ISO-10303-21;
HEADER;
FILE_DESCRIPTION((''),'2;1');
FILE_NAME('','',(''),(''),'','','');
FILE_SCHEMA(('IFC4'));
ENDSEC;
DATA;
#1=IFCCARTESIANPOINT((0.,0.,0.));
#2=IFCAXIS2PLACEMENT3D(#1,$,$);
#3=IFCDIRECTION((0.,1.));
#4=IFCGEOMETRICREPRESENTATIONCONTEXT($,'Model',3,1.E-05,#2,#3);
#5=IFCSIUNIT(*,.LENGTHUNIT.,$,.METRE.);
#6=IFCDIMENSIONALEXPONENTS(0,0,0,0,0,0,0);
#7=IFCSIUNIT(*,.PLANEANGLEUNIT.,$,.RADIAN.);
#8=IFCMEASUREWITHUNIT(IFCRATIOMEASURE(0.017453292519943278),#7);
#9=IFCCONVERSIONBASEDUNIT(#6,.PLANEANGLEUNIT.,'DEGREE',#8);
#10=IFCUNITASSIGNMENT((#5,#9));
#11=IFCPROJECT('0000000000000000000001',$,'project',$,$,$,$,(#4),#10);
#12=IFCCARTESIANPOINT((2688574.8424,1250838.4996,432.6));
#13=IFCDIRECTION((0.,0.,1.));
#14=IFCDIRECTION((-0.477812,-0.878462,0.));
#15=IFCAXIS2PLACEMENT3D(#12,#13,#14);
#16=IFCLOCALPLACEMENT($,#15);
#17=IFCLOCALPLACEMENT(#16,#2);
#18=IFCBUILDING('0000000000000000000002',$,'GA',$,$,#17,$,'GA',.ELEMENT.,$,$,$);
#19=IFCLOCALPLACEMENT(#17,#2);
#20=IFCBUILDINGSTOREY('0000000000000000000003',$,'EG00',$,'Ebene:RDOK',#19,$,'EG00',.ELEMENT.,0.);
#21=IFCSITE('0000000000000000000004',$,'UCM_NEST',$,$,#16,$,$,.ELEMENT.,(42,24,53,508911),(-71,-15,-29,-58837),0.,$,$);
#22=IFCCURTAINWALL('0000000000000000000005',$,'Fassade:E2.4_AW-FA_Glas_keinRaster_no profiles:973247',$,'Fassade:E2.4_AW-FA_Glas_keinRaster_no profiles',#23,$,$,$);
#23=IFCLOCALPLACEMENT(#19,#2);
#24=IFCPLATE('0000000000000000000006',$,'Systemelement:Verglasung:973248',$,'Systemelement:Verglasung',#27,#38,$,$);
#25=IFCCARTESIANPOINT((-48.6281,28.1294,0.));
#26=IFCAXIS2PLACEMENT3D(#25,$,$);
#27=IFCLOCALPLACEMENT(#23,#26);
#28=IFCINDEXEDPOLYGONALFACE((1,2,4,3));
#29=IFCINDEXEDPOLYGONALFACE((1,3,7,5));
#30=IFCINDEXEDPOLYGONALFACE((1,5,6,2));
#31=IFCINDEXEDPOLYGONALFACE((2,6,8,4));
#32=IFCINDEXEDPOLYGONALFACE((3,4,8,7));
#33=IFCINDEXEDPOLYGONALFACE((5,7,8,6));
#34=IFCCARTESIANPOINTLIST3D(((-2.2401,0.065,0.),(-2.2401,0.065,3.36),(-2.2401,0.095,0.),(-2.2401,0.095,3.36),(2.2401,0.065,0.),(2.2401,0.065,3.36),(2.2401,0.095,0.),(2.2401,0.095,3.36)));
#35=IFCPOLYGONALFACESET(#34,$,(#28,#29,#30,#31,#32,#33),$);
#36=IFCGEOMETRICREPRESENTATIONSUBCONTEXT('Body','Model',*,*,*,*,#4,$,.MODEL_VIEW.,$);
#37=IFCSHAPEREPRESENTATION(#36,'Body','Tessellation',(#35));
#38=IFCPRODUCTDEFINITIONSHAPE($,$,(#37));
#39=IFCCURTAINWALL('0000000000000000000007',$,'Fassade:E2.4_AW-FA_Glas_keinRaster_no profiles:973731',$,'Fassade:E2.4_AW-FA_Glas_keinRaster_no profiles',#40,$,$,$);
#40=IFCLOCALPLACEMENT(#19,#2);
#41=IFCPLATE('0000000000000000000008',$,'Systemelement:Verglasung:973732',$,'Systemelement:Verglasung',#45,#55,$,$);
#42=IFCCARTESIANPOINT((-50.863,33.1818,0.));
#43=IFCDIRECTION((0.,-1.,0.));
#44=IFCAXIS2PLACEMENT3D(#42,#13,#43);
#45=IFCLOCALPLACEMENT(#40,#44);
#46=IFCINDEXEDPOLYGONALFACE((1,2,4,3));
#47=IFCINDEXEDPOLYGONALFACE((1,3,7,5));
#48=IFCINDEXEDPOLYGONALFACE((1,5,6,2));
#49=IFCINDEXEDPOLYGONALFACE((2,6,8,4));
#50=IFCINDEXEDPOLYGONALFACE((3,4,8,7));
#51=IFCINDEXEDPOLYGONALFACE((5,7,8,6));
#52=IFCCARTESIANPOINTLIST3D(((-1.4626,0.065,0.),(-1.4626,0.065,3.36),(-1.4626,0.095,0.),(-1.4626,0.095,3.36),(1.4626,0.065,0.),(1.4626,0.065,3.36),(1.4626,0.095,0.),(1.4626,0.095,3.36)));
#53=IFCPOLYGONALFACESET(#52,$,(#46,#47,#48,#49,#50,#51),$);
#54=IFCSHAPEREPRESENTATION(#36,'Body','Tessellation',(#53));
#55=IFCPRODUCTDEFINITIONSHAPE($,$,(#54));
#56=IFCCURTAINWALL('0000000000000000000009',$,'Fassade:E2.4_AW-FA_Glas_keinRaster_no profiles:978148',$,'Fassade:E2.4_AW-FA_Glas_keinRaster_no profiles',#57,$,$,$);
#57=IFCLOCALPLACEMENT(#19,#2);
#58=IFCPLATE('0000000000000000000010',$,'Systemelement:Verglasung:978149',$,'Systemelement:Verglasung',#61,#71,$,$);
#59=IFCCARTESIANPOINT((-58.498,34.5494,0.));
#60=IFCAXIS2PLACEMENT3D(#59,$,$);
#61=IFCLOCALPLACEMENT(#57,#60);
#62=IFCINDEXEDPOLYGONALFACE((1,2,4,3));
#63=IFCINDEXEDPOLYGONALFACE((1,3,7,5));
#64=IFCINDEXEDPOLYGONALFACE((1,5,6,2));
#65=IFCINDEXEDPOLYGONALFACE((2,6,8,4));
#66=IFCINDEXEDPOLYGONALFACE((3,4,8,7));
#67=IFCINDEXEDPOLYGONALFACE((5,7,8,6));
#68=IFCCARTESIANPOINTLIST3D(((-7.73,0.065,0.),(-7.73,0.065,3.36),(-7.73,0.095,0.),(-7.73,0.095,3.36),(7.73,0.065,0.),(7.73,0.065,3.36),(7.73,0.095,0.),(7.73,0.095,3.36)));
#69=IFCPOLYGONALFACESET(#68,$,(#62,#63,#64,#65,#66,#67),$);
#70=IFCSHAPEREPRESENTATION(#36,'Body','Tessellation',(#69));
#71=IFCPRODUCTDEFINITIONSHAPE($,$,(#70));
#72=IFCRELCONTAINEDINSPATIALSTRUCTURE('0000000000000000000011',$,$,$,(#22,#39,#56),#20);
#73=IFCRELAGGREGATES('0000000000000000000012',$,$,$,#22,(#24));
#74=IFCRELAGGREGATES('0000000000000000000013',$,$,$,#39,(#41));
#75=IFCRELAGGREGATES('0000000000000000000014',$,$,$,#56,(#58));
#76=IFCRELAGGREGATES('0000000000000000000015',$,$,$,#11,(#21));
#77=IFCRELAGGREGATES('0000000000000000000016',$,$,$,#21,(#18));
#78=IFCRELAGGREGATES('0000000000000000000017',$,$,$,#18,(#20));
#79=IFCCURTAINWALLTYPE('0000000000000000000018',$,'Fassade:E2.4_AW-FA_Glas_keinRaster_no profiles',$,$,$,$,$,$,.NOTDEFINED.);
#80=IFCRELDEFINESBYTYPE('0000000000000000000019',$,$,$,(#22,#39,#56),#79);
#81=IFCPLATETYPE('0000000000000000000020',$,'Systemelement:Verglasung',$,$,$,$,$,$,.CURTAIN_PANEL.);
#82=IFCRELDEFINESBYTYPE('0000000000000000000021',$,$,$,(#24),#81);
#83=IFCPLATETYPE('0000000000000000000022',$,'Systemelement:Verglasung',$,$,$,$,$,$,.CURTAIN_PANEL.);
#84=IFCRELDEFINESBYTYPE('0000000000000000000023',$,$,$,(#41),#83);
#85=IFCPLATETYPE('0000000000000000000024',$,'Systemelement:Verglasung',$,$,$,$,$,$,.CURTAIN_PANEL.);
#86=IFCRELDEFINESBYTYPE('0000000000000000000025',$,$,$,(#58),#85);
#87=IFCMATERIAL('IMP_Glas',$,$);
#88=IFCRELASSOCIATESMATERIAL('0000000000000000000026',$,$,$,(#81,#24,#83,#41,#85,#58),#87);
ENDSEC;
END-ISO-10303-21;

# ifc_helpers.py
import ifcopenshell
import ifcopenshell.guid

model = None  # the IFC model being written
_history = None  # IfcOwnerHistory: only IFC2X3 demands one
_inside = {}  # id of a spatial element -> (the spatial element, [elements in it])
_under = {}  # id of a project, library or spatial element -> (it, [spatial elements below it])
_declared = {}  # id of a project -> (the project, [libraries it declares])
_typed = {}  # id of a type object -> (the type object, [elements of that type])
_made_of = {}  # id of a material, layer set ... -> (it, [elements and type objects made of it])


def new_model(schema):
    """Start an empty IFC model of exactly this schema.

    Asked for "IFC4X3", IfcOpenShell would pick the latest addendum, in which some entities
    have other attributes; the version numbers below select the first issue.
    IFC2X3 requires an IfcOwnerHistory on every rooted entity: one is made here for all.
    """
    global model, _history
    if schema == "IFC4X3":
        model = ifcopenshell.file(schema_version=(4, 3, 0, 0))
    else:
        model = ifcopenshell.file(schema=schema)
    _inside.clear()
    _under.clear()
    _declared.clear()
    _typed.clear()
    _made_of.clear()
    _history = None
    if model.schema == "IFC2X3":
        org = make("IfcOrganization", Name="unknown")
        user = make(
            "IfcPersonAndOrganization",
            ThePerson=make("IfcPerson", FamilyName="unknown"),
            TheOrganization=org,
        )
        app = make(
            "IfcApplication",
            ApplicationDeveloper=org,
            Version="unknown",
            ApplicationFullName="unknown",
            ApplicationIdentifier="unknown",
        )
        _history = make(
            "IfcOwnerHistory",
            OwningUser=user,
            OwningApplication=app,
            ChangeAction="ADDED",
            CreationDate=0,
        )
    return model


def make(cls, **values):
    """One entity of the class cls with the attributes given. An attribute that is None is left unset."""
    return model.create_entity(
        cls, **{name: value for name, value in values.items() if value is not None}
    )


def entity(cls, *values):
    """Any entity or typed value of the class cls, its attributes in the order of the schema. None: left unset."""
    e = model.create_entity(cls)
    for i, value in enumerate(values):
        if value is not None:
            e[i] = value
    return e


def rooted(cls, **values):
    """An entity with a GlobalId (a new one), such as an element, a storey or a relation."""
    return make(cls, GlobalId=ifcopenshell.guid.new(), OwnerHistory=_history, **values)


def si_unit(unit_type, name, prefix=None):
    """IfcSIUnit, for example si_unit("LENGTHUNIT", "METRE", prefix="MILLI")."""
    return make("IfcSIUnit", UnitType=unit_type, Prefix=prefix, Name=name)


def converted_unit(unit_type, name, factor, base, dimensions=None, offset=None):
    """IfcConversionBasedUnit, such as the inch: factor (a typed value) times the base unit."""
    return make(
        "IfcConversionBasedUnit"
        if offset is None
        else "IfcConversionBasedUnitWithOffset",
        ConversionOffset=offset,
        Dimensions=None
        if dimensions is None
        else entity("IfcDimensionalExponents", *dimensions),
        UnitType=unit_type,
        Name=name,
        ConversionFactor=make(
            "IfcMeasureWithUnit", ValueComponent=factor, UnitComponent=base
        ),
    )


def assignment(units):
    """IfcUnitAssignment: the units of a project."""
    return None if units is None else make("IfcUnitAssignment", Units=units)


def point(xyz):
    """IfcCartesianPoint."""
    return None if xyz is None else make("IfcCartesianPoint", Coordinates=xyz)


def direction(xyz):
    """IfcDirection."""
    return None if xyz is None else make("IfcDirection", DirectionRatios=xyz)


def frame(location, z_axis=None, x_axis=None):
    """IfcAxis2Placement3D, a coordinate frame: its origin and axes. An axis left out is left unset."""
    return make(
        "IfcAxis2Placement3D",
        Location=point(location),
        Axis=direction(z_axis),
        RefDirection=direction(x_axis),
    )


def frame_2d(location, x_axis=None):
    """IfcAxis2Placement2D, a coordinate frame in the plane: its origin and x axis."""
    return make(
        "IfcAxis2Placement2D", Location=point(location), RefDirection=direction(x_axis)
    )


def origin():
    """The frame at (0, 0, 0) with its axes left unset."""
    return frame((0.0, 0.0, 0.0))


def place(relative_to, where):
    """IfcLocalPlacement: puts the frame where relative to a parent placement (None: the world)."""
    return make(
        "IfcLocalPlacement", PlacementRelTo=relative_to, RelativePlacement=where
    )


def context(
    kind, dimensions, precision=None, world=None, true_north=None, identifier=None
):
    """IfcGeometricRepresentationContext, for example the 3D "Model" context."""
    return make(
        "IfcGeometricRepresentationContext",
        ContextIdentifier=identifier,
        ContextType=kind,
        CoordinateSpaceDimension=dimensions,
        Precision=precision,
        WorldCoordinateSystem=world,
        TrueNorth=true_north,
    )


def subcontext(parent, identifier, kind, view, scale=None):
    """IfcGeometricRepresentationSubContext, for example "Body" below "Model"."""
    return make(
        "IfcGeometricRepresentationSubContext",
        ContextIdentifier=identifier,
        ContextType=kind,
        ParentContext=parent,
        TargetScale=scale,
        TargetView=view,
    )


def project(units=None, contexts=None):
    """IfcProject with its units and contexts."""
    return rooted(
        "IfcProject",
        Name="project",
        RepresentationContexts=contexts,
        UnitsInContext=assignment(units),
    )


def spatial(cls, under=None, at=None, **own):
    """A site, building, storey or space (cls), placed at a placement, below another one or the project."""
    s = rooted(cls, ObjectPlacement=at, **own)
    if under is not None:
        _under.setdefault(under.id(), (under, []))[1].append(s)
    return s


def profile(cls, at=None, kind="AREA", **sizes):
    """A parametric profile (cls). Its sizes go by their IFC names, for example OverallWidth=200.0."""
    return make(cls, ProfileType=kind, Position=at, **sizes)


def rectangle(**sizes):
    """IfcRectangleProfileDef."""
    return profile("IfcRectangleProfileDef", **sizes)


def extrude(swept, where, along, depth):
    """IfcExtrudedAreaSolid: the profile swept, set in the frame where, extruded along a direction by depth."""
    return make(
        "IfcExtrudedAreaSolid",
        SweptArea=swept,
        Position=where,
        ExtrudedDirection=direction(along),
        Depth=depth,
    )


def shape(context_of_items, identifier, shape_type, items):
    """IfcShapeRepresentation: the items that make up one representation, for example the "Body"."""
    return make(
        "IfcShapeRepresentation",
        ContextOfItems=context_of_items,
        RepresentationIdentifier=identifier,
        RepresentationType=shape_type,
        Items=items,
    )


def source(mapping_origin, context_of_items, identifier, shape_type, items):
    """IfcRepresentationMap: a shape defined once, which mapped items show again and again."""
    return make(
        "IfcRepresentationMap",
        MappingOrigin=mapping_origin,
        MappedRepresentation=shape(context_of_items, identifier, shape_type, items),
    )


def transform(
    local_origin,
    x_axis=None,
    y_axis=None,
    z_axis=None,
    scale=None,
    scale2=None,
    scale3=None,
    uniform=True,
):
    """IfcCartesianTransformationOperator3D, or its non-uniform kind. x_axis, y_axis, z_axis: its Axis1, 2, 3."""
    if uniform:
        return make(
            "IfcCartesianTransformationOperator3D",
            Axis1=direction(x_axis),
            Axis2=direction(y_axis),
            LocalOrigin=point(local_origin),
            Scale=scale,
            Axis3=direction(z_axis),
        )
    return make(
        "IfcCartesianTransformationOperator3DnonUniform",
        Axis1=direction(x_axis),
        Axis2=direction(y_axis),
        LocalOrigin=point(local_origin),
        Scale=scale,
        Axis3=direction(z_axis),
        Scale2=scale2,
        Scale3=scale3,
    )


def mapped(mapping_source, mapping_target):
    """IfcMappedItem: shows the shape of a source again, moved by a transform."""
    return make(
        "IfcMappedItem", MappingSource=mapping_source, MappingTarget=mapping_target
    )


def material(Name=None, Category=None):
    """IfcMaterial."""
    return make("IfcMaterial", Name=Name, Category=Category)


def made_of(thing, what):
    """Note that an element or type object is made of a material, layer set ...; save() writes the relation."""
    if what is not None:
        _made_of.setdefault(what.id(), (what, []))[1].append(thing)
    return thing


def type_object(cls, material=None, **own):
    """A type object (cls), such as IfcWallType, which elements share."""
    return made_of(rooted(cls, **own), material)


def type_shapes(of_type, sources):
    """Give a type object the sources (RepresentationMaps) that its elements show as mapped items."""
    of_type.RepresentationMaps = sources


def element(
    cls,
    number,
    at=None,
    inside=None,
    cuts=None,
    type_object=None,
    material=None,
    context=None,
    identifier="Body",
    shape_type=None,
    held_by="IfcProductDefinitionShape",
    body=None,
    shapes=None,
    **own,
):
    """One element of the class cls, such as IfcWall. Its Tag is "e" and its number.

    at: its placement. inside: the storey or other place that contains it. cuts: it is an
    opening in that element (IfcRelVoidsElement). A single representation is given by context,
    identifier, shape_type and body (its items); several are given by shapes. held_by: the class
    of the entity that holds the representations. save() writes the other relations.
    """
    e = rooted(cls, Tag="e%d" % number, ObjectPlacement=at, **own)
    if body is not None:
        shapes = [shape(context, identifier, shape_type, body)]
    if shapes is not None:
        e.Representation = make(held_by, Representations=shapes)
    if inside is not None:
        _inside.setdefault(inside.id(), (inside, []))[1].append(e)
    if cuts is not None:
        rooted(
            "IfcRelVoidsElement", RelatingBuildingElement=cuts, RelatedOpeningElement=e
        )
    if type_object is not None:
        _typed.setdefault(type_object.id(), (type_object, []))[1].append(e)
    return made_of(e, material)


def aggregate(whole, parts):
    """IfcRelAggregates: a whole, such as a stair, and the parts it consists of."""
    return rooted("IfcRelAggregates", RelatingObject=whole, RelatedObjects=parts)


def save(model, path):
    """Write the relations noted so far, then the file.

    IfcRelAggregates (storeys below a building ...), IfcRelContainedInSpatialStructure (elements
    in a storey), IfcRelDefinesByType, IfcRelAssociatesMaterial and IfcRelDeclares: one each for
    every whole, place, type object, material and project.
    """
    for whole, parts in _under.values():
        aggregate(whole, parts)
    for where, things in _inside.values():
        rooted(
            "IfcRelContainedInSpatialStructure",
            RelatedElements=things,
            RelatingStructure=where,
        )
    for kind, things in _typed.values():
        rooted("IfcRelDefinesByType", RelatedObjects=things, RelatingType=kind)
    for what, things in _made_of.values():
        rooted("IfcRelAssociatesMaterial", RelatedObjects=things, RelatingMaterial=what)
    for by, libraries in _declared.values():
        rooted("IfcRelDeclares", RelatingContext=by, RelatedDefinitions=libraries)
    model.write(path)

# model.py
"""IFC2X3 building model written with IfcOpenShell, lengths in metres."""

from ifc_helpers import new_model, entity, si_unit, converted_unit, direction, frame, frame_2d, origin, place, context, subcontext, project, spatial, rectangle, extrude, source, transform, mapped, material, type_object, type_shapes, element, aggregate, save


model = new_model("IFC2X3")

# Units and contexts
model_context = context("Model", 3, precision=1e-05, world=origin(), true_north=direction((0.0, 1.0)))
body_context = subcontext(model_context, "Body", "Model", "MODEL_VIEW")
ifc_project = project(units=[si_unit("LENGTHUNIT", "METRE"), converted_unit("PLANEANGLEUNIT", "DEGREE", entity("IfcRatioMeasure", 0.017453292519943278), si_unit("PLANEANGLEUNIT", "RADIAN"), dimensions=[0, 0, 0, 0, 0, 0, 0])], contexts=[model_context])

# Site, building, storey
site_placement = place(None, frame((2688574.8424, 1250838.4996, 432.6), z_axis=(0.0, 0.0, 1.0), x_axis=(-0.477812, -0.878462, 0.0)))
site = spatial("IfcSite", under=ifc_project, at=site_placement, Name="UCM_NEST", CompositionType="ELEMENT", RefLatitude=(42, 24, 53, 508911), RefLongitude=(-71, -15, -29, -58837), RefElevation=0.0)
building_placement = place(site_placement, origin())
building = spatial("IfcBuilding", under=site, at=building_placement, Name="GA", LongName="GA", CompositionType="ELEMENT")
storey_placement = place(building_placement, origin())
storey = spatial("IfcBuildingStorey", under=building, at=storey_placement, Name="EG00", ObjectType="Ebene:RDOK", LongName="EG00", CompositionType="ELEMENT", Elevation=0.0)

# Curtain walls, plates
curtain_wall_type = type_object("IfcCurtainWallType", Name="Fassade:E2.4_AW-FA_Glas_keinRaster_no profiles", PredefinedType="NOTDEFINED")
curtain_wall_1_placement = place(storey_placement, origin())
curtain_wall_1 = element("IfcCurtainWall", 1, at=curtain_wall_1_placement, inside=storey, type_object=curtain_wall_type, Name="Fassade:E2.4_AW-FA_Glas_keinRaster_no profiles:973247", ObjectType="Fassade:E2.4_AW-FA_Glas_keinRaster_no profiles")
ifc_material_1 = material(Name="IMP_Glas")
plate_type_1 = type_object("IfcPlateType", Name="Systemelement:Verglasung", PredefinedType="CURTAIN_PANEL", material=ifc_material_1)
shared_shape_1 = source(origin(), body_context, "Body", "SweptSolid", [
    extrude(rectangle(XDim=0.03, YDim=4.4801, at=frame_2d((0.0, 0.0), x_axis=(1.0, 0.0))), frame((0.0, 0.08, 0.0), z_axis=(0.0, 0.0, 1.0), x_axis=(0.0, 1.0, 0.0)), (0.0, 0.0, 1.0), 3.36),
])
type_shapes(plate_type_1, [shared_shape_1])
plate_1_placement = place(curtain_wall_1_placement, frame((-48.6281, 28.1294, 0.0)))
plate_1 = element("IfcPlate", 2, at=plate_1_placement, type_object=plate_type_1, material=ifc_material_1, Name="Systemelement:Verglasung:973248", ObjectType="Systemelement:Verglasung", context=body_context, shape_type="MappedRepresentation", body=[
    mapped(shared_shape_1, transform((0.0, 0.0, 0.0), scale=1.0)),
])
aggregate(curtain_wall_1, [plate_1])
curtain_wall_2_placement = place(storey_placement, origin())
curtain_wall_2 = element("IfcCurtainWall", 3, at=curtain_wall_2_placement, inside=storey, type_object=curtain_wall_type, Name="Fassade:E2.4_AW-FA_Glas_keinRaster_no profiles:973731", ObjectType="Fassade:E2.4_AW-FA_Glas_keinRaster_no profiles")
plate_type_2 = type_object("IfcPlateType", Name="Systemelement:Verglasung", PredefinedType="CURTAIN_PANEL", material=ifc_material_1)
shared_shape_2 = source(origin(), body_context, "Body", "SweptSolid", [
    extrude(rectangle(XDim=0.03, YDim=2.9253, at=frame_2d((0.0, 0.0), x_axis=(1.0, 0.0))), frame((0.0, 0.08, 0.0), z_axis=(0.0, 0.0, 1.0), x_axis=(0.0, 1.0, 0.0)), (0.0, 0.0, 1.0), 3.36),
])
type_shapes(plate_type_2, [shared_shape_2])
plate_2_placement = place(curtain_wall_2_placement, frame((-50.863, 33.1818, 0.0), z_axis=(0.0, 0.0, 1.0), x_axis=(0.0, -1.0, 0.0)))
plate_2 = element("IfcPlate", 4, at=plate_2_placement, type_object=plate_type_2, material=ifc_material_1, Name="Systemelement:Verglasung:973732", ObjectType="Systemelement:Verglasung", context=body_context, shape_type="MappedRepresentation", body=[
    mapped(shared_shape_2, transform((0.0, 0.0, 0.0), scale=1.0)),
])
aggregate(curtain_wall_2, [plate_2])
curtain_wall_3_placement = place(storey_placement, origin())
curtain_wall_3 = element("IfcCurtainWall", 5, at=curtain_wall_3_placement, inside=storey, type_object=curtain_wall_type, Name="Fassade:E2.4_AW-FA_Glas_keinRaster_no profiles:978148", ObjectType="Fassade:E2.4_AW-FA_Glas_keinRaster_no profiles")
plate_type_3 = type_object("IfcPlateType", Name="Systemelement:Verglasung", PredefinedType="CURTAIN_PANEL", material=ifc_material_1)
shared_shape_3 = source(origin(), body_context, "Body", "SweptSolid", [
    extrude(rectangle(XDim=0.03, YDim=15.46, at=frame_2d((0.0, 0.0), x_axis=(1.0, 0.0))), frame((0.0, 0.08, 0.0), z_axis=(0.0, 0.0, 1.0), x_axis=(0.0, 1.0, 0.0)), (0.0, 0.0, 1.0), 3.36),
])
type_shapes(plate_type_3, [shared_shape_3])
plate_3_placement = place(curtain_wall_3_placement, frame((-58.498, 34.5494, 0.0)))
plate_3 = element("IfcPlate", 6, at=plate_3_placement, type_object=plate_type_3, material=ifc_material_1, Name="Systemelement:Verglasung:978149", ObjectType="Systemelement:Verglasung", context=body_context, shape_type="MappedRepresentation", body=[
    mapped(shared_shape_3, transform((0.0, 0.0, 0.0), scale=1.0)),
])
aggregate(curtain_wall_3, [plate_3])

save(model, "model.ifc")
